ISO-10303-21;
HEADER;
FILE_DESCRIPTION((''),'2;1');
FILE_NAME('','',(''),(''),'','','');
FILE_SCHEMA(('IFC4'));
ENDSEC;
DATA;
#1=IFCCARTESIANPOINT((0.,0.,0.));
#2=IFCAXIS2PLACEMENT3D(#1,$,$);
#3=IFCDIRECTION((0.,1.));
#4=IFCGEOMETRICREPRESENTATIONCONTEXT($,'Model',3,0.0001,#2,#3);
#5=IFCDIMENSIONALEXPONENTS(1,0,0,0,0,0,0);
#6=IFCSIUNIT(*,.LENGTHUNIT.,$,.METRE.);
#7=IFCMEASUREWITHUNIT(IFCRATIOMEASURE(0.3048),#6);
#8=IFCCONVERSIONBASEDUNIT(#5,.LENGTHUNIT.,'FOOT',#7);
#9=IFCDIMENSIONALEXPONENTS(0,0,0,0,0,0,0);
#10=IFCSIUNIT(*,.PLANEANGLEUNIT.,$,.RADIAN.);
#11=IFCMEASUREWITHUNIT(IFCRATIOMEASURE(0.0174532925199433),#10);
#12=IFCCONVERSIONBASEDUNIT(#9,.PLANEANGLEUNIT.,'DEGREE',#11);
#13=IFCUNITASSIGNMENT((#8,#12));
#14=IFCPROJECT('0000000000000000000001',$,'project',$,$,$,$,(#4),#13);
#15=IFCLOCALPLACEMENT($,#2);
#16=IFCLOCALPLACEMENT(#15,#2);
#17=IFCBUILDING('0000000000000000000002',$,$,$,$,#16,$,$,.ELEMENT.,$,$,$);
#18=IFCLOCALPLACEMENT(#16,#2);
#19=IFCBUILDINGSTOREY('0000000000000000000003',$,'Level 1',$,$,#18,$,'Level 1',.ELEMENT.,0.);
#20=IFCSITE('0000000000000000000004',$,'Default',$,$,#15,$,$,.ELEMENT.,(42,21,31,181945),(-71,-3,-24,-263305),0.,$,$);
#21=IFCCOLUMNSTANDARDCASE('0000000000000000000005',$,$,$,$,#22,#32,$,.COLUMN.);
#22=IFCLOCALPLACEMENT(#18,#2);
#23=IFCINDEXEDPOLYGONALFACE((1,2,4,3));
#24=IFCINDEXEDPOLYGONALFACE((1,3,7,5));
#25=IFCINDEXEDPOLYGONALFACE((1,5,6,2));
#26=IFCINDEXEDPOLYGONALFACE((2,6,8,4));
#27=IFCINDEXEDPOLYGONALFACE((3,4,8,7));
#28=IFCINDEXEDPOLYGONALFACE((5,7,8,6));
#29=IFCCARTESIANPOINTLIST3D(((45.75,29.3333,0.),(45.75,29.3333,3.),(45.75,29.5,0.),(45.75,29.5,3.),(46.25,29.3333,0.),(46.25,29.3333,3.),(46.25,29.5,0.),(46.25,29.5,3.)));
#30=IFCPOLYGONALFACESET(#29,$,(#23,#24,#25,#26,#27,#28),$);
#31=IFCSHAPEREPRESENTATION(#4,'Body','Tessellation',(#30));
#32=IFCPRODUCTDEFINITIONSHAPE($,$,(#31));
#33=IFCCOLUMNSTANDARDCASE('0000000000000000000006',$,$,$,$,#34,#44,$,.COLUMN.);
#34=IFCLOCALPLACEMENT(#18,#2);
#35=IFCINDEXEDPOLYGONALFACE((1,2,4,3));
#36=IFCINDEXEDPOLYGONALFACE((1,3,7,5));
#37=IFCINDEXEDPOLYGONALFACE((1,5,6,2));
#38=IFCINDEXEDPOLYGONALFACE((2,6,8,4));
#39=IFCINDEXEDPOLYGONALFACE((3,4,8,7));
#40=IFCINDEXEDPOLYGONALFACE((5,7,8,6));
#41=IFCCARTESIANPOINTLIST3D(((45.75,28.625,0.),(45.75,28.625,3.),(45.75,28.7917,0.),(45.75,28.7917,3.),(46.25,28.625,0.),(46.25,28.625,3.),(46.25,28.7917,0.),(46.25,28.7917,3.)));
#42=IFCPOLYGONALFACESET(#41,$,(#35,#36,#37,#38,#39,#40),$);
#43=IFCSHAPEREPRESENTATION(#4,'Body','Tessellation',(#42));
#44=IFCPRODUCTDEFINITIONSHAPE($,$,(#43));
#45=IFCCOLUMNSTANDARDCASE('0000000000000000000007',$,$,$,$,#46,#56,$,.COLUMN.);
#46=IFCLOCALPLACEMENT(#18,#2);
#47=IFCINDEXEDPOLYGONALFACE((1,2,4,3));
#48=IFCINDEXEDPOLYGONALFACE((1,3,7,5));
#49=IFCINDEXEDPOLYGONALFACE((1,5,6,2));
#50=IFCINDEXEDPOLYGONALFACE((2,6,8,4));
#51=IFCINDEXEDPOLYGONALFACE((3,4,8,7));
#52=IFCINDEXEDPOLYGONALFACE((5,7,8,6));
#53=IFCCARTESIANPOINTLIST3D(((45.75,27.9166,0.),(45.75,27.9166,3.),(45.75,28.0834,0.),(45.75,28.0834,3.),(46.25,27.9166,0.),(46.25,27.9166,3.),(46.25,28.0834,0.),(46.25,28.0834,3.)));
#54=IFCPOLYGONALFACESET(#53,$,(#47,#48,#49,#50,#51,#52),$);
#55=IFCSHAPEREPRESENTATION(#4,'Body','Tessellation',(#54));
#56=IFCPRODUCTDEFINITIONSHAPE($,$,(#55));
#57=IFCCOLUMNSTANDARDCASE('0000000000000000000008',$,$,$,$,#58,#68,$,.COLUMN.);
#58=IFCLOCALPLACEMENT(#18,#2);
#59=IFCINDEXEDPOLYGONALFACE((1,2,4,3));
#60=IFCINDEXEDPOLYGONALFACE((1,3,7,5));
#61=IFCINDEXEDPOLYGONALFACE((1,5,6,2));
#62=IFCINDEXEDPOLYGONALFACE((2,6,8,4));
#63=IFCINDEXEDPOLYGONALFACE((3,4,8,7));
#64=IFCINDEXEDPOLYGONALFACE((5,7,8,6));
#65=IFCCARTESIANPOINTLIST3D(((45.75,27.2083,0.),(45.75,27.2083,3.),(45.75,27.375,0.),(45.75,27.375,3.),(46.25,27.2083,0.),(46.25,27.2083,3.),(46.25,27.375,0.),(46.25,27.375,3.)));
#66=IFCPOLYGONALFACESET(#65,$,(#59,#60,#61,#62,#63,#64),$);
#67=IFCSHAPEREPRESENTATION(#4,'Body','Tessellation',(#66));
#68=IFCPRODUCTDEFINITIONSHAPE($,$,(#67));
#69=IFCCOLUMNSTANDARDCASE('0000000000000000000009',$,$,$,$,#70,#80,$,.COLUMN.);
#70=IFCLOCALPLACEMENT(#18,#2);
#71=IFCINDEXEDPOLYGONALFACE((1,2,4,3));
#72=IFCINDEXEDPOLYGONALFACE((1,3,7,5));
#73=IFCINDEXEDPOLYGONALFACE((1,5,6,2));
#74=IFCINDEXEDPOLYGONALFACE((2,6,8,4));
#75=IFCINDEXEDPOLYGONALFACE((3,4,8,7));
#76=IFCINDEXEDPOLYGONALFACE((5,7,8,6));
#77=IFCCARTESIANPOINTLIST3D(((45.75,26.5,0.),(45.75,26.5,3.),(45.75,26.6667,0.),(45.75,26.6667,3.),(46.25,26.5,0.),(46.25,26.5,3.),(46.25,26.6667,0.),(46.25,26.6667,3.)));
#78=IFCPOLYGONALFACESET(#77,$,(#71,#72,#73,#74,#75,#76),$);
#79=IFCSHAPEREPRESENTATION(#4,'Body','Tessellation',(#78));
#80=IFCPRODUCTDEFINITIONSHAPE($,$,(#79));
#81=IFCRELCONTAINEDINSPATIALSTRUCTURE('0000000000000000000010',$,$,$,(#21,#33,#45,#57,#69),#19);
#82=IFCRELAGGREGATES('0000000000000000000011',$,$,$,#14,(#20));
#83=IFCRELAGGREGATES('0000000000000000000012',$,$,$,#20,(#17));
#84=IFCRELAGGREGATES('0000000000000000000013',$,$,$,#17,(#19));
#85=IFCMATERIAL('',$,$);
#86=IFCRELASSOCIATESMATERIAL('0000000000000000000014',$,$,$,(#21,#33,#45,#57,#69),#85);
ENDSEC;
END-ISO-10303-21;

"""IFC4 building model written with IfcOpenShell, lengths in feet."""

from ifc_helpers import new_model, entity, si_unit, converted_unit, direction, frame, origin, place, context, project, spatial, rectangle, extrude, material, element, save


model = new_model("IFC4")

# Units and contexts
model_context = context("Model", 3, precision=0.0001, world=origin(), true_north=direction((0.0, 1.0)))
ifc_project = project(units=[converted_unit("LENGTHUNIT", "FOOT", entity("IfcRatioMeasure", 0.3048), si_unit("LENGTHUNIT", "METRE"), dimensions=[1, 0, 0, 0, 0, 0, 0]), converted_unit("PLANEANGLEUNIT", "DEGREE", entity("IfcRatioMeasure", 0.0174532925199433), si_unit("PLANEANGLEUNIT", "RADIAN"), dimensions=[0, 0, 0, 0, 0, 0, 0])], contexts=[model_context])

# Site, building, storey
site_placement = place(None, origin())
site = spatial("IfcSite", under=ifc_project, at=site_placement, Name="Default", CompositionType="ELEMENT", RefLatitude=(42, 21, 31, 181945), RefLongitude=(-71, -3, -24, -263305), RefElevation=0.0)
building_placement = place(site_placement, origin())
building = spatial("IfcBuilding", under=site, at=building_placement, CompositionType="ELEMENT")
storey_placement = place(building_placement, origin())
storey = spatial("IfcBuildingStorey", under=building, at=storey_placement, Name="Level 1", LongName="Level 1", CompositionType="ELEMENT", Elevation=0.0)

# Columns
placement = place(storey_placement, frame((46.0, 46.25, 0.0), z_axis=(0.0, 0.0, 1.0), x_axis=(0.0, -1.0, 0.0)))
ifc_material_1 = material(Name="")
for number, where, z_axis, x_axis in (
    (1, (16.8334, 0.0, 0.0), (0.0, 0.0, 1.0), (1.0, 0.0, 0.0)),
    (2, (17.5417, 0.0, 0.0), (0.0, 0.0, 1.0), (1.0, 0.0, 0.0)),
    (3, (18.25, 0.0, 0.0), (0.0, 0.0, 1.0), (1.0, 0.0, 0.0)),
    (4, (18.9583, 0.0, 0.0), (0.0, 0.0, 1.0), (1.0, 0.0, 0.0)),
    (5, (19.6667, 0.0, 0.0), (0.0, 0.0, 1.0), (1.0, 0.0, 0.0)),
):
    element("IfcColumnStandardCase", number, at=place(placement, frame(where, z_axis=z_axis, x_axis=x_axis)), inside=storey, material=ifc_material_1, PredefinedType="COLUMN", context=model_context, shape_type="SweptSolid", body=[
        extrude(rectangle(XDim=0.1667, YDim=0.5), origin(), (0.0, 0.0, 1.0), 3.0),
    ])

save(model, "model.ifc")
